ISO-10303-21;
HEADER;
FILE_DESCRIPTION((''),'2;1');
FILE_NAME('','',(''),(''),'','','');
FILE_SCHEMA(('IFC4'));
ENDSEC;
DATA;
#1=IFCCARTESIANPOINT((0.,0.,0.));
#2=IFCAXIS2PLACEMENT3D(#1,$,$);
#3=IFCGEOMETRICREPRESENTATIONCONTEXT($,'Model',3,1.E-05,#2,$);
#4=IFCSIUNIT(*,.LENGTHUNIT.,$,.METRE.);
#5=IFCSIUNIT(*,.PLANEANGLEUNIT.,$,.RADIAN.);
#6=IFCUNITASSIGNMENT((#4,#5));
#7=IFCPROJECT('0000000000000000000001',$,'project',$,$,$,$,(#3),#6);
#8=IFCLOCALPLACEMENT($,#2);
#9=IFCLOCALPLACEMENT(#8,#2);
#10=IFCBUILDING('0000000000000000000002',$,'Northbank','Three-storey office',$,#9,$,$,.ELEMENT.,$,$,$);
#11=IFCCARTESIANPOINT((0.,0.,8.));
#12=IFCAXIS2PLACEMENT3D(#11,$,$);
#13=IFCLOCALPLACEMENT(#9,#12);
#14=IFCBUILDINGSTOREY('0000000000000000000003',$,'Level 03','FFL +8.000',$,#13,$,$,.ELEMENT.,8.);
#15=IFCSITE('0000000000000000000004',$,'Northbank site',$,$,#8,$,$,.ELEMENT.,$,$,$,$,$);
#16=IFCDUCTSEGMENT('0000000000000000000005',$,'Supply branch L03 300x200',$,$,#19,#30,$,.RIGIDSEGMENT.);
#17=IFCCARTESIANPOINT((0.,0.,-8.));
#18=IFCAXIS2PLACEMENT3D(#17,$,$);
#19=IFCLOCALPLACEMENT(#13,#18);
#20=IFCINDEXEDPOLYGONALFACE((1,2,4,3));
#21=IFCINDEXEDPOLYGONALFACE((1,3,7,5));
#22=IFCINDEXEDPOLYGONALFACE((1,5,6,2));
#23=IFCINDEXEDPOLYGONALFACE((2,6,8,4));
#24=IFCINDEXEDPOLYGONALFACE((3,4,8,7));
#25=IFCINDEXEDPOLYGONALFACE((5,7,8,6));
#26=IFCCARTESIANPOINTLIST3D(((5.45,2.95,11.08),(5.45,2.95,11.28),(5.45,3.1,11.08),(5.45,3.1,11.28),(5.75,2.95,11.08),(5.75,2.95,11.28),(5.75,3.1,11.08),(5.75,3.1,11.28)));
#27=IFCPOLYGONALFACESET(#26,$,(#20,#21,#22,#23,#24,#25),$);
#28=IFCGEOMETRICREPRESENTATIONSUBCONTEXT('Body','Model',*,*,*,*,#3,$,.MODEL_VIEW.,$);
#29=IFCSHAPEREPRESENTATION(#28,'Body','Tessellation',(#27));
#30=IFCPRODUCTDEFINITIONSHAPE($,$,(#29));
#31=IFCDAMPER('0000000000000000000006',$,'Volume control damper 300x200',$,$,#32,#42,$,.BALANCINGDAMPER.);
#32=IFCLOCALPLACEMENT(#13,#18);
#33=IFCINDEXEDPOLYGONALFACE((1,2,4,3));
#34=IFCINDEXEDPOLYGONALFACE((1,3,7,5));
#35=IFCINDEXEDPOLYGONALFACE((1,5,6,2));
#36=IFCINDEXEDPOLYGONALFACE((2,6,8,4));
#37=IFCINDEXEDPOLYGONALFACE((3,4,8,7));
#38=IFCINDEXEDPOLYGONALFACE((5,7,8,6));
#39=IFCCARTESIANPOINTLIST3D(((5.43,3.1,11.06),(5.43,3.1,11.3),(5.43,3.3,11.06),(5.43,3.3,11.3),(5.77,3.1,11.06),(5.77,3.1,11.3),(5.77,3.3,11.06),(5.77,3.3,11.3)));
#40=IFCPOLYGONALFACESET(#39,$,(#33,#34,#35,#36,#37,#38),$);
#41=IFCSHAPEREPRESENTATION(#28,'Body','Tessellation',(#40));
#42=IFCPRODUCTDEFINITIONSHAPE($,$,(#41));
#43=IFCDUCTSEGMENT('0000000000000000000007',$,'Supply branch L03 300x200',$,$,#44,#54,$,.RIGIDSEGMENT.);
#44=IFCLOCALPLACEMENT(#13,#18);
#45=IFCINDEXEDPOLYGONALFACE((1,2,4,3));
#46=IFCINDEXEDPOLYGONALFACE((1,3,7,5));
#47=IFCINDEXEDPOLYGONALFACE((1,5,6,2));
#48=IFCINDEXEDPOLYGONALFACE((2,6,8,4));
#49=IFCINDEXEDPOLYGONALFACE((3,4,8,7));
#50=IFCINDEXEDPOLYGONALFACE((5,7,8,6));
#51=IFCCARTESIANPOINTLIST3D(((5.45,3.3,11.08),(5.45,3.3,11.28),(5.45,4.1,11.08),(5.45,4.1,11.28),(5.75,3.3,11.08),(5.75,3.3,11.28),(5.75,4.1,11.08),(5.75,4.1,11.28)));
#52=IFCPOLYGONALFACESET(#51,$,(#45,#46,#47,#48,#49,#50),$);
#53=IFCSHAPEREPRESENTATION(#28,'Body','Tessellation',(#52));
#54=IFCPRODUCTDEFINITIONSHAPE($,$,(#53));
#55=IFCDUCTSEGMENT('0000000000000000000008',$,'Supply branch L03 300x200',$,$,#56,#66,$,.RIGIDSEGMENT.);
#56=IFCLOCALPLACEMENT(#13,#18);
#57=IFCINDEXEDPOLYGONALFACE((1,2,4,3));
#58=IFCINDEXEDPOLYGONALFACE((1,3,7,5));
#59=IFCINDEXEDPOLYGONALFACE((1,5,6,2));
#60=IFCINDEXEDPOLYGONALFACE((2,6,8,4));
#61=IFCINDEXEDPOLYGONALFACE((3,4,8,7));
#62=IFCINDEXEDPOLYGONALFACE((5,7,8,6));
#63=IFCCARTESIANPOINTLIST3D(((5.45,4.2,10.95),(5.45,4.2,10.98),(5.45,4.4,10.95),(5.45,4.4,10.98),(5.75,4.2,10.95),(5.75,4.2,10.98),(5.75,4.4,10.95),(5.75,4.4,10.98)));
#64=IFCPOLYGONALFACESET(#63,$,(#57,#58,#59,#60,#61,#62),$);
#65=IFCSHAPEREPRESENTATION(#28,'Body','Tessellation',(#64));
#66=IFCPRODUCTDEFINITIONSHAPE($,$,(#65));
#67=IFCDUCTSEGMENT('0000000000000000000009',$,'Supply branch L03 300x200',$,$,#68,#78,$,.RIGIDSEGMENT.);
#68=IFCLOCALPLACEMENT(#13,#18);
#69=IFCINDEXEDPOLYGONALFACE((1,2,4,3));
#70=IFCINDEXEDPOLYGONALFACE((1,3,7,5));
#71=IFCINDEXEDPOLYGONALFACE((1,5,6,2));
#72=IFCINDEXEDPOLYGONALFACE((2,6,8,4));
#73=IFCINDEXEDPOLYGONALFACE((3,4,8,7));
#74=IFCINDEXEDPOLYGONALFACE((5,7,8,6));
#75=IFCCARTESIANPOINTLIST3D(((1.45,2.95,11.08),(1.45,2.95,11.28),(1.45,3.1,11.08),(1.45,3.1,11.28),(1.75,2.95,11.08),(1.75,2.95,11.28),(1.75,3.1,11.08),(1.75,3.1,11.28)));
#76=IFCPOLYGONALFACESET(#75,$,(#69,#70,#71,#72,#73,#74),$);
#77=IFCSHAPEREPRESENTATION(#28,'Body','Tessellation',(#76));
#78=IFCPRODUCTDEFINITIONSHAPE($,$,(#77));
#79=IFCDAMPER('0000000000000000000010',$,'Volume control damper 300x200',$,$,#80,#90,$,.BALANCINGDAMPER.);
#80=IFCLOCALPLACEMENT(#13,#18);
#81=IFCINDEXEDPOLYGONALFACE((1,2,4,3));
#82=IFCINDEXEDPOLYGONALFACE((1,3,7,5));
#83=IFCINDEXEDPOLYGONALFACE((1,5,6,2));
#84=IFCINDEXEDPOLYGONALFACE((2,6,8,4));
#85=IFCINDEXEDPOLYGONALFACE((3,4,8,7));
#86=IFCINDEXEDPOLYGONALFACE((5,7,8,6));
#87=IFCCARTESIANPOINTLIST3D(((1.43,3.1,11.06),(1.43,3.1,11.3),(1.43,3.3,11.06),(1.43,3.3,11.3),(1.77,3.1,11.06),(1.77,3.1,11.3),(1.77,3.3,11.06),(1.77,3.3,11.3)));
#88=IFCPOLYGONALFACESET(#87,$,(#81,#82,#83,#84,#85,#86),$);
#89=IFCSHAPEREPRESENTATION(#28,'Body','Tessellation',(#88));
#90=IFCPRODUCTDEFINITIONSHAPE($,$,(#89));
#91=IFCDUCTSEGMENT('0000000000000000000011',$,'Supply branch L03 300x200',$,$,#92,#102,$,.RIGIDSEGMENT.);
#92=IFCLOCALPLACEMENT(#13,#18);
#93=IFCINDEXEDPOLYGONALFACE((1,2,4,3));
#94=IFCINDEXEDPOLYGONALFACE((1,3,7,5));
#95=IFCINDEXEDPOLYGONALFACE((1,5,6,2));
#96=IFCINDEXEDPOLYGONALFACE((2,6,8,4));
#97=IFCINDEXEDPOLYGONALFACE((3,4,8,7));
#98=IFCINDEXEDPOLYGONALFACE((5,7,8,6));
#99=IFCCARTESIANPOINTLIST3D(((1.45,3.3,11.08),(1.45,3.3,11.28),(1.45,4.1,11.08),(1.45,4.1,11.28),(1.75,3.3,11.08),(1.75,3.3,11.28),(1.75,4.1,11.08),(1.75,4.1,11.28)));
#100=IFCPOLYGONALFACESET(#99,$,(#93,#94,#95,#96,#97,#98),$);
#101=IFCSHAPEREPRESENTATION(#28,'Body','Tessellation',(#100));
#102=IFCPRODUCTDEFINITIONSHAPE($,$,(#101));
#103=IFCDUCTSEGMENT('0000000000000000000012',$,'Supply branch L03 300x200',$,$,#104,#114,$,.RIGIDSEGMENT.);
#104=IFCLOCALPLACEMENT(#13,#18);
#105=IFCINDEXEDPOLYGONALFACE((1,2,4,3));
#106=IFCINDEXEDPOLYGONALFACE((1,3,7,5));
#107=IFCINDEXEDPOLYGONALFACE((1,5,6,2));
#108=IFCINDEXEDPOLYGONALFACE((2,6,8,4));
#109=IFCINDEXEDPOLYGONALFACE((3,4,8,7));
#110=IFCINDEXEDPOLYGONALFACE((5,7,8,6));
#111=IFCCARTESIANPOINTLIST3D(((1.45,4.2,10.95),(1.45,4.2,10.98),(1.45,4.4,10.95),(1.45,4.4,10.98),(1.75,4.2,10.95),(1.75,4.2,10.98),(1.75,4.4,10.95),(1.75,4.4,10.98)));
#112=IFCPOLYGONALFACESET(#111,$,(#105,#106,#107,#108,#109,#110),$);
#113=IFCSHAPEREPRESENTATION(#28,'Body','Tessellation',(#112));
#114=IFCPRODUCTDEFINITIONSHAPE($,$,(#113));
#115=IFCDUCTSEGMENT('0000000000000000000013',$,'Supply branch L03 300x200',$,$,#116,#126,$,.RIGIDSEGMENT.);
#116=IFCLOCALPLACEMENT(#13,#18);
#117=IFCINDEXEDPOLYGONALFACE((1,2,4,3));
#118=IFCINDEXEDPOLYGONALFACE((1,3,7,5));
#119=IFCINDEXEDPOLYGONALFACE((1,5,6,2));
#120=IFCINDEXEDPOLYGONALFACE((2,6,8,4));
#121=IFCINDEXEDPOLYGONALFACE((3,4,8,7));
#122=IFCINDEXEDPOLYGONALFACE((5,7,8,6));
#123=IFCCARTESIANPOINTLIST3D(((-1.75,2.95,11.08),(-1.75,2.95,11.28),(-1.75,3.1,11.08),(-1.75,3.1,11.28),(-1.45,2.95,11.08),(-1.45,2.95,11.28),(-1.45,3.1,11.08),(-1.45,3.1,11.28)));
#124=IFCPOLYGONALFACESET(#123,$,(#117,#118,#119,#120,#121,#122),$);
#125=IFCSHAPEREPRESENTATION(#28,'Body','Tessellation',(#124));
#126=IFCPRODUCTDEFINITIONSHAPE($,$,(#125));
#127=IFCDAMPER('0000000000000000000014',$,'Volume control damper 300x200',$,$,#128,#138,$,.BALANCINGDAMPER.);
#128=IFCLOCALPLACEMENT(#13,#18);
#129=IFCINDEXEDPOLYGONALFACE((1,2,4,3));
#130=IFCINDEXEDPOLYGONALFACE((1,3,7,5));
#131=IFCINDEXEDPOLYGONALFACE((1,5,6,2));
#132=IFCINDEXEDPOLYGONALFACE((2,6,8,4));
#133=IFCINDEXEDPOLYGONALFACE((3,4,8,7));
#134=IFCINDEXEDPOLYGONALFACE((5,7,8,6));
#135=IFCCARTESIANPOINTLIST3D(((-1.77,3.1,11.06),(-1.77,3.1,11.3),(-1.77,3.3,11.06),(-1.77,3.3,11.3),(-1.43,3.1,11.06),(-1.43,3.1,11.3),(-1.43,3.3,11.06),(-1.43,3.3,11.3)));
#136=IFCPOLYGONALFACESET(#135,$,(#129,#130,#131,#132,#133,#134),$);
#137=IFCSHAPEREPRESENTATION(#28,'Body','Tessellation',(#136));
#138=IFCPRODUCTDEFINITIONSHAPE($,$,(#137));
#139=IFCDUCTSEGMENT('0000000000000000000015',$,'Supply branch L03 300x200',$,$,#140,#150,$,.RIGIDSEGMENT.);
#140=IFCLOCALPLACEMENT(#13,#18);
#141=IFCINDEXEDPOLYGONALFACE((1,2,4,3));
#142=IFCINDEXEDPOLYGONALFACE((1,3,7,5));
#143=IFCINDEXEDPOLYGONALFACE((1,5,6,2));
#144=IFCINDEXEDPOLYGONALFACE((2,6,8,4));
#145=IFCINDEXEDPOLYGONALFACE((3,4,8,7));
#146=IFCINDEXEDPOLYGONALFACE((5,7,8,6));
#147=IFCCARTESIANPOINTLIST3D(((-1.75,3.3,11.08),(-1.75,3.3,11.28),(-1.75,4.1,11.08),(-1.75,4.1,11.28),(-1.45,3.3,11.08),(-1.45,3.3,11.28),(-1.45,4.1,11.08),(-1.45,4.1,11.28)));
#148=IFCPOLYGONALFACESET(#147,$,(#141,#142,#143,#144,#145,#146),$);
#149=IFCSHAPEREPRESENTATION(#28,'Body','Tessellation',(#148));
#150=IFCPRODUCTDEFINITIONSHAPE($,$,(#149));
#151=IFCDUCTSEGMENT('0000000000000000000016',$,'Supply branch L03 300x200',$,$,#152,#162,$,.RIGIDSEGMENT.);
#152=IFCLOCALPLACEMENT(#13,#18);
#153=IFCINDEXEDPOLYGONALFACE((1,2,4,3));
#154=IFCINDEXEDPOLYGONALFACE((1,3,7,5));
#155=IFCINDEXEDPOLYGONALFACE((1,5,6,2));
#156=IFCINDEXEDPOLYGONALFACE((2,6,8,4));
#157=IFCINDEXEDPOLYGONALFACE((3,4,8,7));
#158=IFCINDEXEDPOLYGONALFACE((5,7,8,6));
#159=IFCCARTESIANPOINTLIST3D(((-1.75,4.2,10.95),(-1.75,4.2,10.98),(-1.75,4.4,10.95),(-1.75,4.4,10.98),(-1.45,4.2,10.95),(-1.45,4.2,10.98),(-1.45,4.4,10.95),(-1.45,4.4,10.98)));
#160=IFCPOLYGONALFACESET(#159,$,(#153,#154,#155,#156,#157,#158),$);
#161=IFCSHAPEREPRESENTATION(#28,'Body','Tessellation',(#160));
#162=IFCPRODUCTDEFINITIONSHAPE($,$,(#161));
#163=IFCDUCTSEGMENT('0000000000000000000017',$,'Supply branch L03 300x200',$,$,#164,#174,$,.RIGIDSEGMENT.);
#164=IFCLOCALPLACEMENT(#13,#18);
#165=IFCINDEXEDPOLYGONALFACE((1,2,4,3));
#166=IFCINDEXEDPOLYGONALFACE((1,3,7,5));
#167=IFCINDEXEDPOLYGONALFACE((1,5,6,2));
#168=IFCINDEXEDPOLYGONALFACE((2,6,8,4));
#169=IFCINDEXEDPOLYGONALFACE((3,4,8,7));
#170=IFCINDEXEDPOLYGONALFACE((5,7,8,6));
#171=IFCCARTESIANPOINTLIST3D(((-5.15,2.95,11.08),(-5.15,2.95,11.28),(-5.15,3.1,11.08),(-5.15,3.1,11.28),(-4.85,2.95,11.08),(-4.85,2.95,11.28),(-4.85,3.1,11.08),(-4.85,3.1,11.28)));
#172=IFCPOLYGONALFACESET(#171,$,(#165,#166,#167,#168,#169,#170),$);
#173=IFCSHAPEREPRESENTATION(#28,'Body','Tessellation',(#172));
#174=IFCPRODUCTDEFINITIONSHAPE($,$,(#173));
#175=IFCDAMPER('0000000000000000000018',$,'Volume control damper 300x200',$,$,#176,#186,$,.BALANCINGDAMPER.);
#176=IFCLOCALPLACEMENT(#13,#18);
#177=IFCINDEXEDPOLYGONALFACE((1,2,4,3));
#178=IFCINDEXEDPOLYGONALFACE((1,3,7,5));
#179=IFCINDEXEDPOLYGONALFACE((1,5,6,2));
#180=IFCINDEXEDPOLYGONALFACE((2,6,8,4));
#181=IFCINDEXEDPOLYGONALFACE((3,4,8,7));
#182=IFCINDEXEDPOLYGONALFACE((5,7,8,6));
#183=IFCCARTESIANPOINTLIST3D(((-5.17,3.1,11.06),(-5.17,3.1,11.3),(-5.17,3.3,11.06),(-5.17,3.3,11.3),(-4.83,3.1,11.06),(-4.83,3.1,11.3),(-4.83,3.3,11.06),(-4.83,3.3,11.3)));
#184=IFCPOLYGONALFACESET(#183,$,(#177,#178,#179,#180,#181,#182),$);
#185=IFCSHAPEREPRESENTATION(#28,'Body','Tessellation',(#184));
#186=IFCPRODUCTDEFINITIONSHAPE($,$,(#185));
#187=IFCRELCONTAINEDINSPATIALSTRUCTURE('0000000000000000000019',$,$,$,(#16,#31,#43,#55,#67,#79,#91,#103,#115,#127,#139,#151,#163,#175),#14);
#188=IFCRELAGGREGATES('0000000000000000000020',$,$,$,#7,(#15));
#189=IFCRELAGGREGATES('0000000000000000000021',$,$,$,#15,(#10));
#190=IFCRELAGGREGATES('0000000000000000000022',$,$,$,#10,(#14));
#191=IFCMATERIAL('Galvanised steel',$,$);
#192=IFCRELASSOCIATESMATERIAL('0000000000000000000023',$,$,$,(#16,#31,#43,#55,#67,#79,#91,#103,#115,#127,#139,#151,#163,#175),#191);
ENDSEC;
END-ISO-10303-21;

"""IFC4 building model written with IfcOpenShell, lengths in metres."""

from ifc_helpers import new_model, si_unit, frame, origin, place, context, subcontext, project, spatial, rectangle, extrude, material, element, save


model = new_model("IFC4")

# Units and contexts
model_context = context("Model", 3, precision=1e-05, world=origin())
body_context = subcontext(model_context, "Body", "Model", "MODEL_VIEW")
ifc_project = project(units=[si_unit("LENGTHUNIT", "METRE"), si_unit("PLANEANGLEUNIT", "RADIAN")], contexts=[model_context])

# Site, building, storey
site_placement = place(None, origin())
site = spatial("IfcSite", under=ifc_project, at=site_placement, Name="Northbank site", CompositionType="ELEMENT")
building_placement = place(site_placement, origin())
building = spatial("IfcBuilding", under=site, at=building_placement, Name="Northbank", Description="Three-storey office", CompositionType="ELEMENT")
storey_placement = place(building_placement, frame((0.0, 0.0, 8.0)))
storey = spatial("IfcBuildingStorey", under=building, at=storey_placement, Name="Level 03", Description="FFL +8.000", CompositionType="ELEMENT", Elevation=8.0)

# Duct segment
ifc_material_1 = material(Name="Galvanised steel")
duct_segment_1_placement = place(storey_placement, frame((0.0, 0.0, -8.0)))
element("IfcDuctSegment", 1, at=duct_segment_1_placement, inside=storey, material=ifc_material_1, Name="Supply branch L03 300x200", PredefinedType="RIGIDSEGMENT", context=body_context, shape_type="SweptSolid", body=[
    extrude(rectangle(XDim=0.3, YDim=0.2), frame((5.6, 2.95, 11.18), z_axis=(0.0, 1.0, 0.0), x_axis=(-1.0, 0.0, 0.0)), (0.0, 0.0, 1.0), 0.15),
])

# Damper
damper_1_placement = place(storey_placement, frame((0.0, 0.0, -8.0)))
element("IfcDamper", 2, at=damper_1_placement, inside=storey, material=ifc_material_1, Name="Volume control damper 300x200", PredefinedType="BALANCINGDAMPER", context=body_context, shape_type="SweptSolid", body=[
    extrude(rectangle(XDim=0.34, YDim=0.24), frame((5.6, 3.1, 11.18), z_axis=(0.0, 1.0, 0.0), x_axis=(-1.0, 0.0, 0.0)), (0.0, 0.0, 1.0), 0.2),
])

# Duct segments
duct_segment_2_placement = place(storey_placement, frame((0.0, 0.0, -8.0)))
element("IfcDuctSegment", 3, at=duct_segment_2_placement, inside=storey, material=ifc_material_1, Name="Supply branch L03 300x200", PredefinedType="RIGIDSEGMENT", context=body_context, shape_type="SweptSolid", body=[
    extrude(rectangle(XDim=0.3, YDim=0.2), frame((5.6, 3.3, 11.18), z_axis=(0.0, 1.0, 0.0), x_axis=(-1.0, 0.0, 0.0)), (0.0, 0.0, 1.0), 0.8),
])
duct_segment_3_placement = place(storey_placement, frame((0.0, 0.0, -8.0)))
element("IfcDuctSegment", 4, at=duct_segment_3_placement, inside=storey, material=ifc_material_1, Name="Supply branch L03 300x200", PredefinedType="RIGIDSEGMENT", context=body_context, shape_type="SweptSolid", body=[
    extrude(rectangle(XDim=0.3, YDim=0.2), frame((5.6, 4.3, 10.98), z_axis=(0.0, 0.0, -1.0), x_axis=(-1.0, 0.0, 0.0)), (0.0, 0.0, 1.0), 0.03),
])

# Duct segment
duct_segment_4_placement = place(storey_placement, frame((0.0, 0.0, -8.0)))
element("IfcDuctSegment", 5, at=duct_segment_4_placement, inside=storey, material=ifc_material_1, Name="Supply branch L03 300x200", PredefinedType="RIGIDSEGMENT", context=body_context, shape_type="SweptSolid", body=[
    extrude(rectangle(XDim=0.3, YDim=0.2), frame((1.6, 2.95, 11.18), z_axis=(0.0, 1.0, 0.0), x_axis=(-1.0, 0.0, 0.0)), (0.0, 0.0, 1.0), 0.15),
])

# Damper
damper_2_placement = place(storey_placement, frame((0.0, 0.0, -8.0)))
element("IfcDamper", 6, at=damper_2_placement, inside=storey, material=ifc_material_1, Name="Volume control damper 300x200", PredefinedType="BALANCINGDAMPER", context=body_context, shape_type="SweptSolid", body=[
    extrude(rectangle(XDim=0.34, YDim=0.24), frame((1.6, 3.1, 11.18), z_axis=(0.0, 1.0, 0.0), x_axis=(-1.0, 0.0, 0.0)), (0.0, 0.0, 1.0), 0.2),
])

# Duct segments
duct_segment_5_placement = place(storey_placement, frame((0.0, 0.0, -8.0)))
element("IfcDuctSegment", 7, at=duct_segment_5_placement, inside=storey, material=ifc_material_1, Name="Supply branch L03 300x200", PredefinedType="RIGIDSEGMENT", context=body_context, shape_type="SweptSolid", body=[
    extrude(rectangle(XDim=0.3, YDim=0.2), frame((1.6, 3.3, 11.18), z_axis=(0.0, 1.0, 0.0), x_axis=(-1.0, 0.0, 0.0)), (0.0, 0.0, 1.0), 0.8),
])
duct_segment_6_placement = place(storey_placement, frame((0.0, 0.0, -8.0)))
element("IfcDuctSegment", 8, at=duct_segment_6_placement, inside=storey, material=ifc_material_1, Name="Supply branch L03 300x200", PredefinedType="RIGIDSEGMENT", context=body_context, shape_type="SweptSolid", body=[
    extrude(rectangle(XDim=0.3, YDim=0.2), frame((1.6, 4.3, 10.98), z_axis=(0.0, 0.0, -1.0), x_axis=(-1.0, 0.0, 0.0)), (0.0, 0.0, 1.0), 0.03),
])

# Duct segment
duct_segment_7_placement = place(storey_placement, frame((0.0, 0.0, -8.0)))
element("IfcDuctSegment", 9, at=duct_segment_7_placement, inside=storey, material=ifc_material_1, Name="Supply branch L03 300x200", PredefinedType="RIGIDSEGMENT", context=body_context, shape_type="SweptSolid", body=[
    extrude(rectangle(XDim=0.3, YDim=0.2), frame((-1.6, 2.95, 11.18), z_axis=(0.0, 1.0, 0.0), x_axis=(-1.0, 0.0, 0.0)), (0.0, 0.0, 1.0), 0.15),
])

# Damper
damper_3_placement = place(storey_placement, frame((0.0, 0.0, -8.0)))
element("IfcDamper", 10, at=damper_3_placement, inside=storey, material=ifc_material_1, Name="Volume control damper 300x200", PredefinedType="BALANCINGDAMPER", context=body_context, shape_type="SweptSolid", body=[
    extrude(rectangle(XDim=0.34, YDim=0.24), frame((-1.6, 3.1, 11.18), z_axis=(0.0, 1.0, 0.0), x_axis=(-1.0, 0.0, 0.0)), (0.0, 0.0, 1.0), 0.2),
])

# Duct segments
duct_segment_8_placement = place(storey_placement, frame((0.0, 0.0, -8.0)))
element("IfcDuctSegment", 11, at=duct_segment_8_placement, inside=storey, material=ifc_material_1, Name="Supply branch L03 300x200", PredefinedType="RIGIDSEGMENT", context=body_context, shape_type="SweptSolid", body=[
    extrude(rectangle(XDim=0.3, YDim=0.2), frame((-1.6, 3.3, 11.18), z_axis=(0.0, 1.0, 0.0), x_axis=(-1.0, 0.0, 0.0)), (0.0, 0.0, 1.0), 0.8),
])
duct_segment_9_placement = place(storey_placement, frame((0.0, 0.0, -8.0)))
element("IfcDuctSegment", 12, at=duct_segment_9_placement, inside=storey, material=ifc_material_1, Name="Supply branch L03 300x200", PredefinedType="RIGIDSEGMENT", context=body_context, shape_type="SweptSolid", body=[
    extrude(rectangle(XDim=0.3, YDim=0.2), frame((-1.6, 4.3, 10.98), z_axis=(0.0, 0.0, -1.0), x_axis=(-1.0, 0.0, 0.0)), (0.0, 0.0, 1.0), 0.03),
])

# Duct segment
duct_segment_10_placement = place(storey_placement, frame((0.0, 0.0, -8.0)))
element("IfcDuctSegment", 13, at=duct_segment_10_placement, inside=storey, material=ifc_material_1, Name="Supply branch L03 300x200", PredefinedType="RIGIDSEGMENT", context=body_context, shape_type="SweptSolid", body=[
    extrude(rectangle(XDim=0.3, YDim=0.2), frame((-5.0, 2.95, 11.18), z_axis=(0.0, 1.0, 0.0), x_axis=(-1.0, 0.0, 0.0)), (0.0, 0.0, 1.0), 0.15),
])

# Damper
damper_4_placement = place(storey_placement, frame((0.0, 0.0, -8.0)))
element("IfcDamper", 14, at=damper_4_placement, inside=storey, material=ifc_material_1, Name="Volume control damper 300x200", PredefinedType="BALANCINGDAMPER", context=body_context, shape_type="SweptSolid", body=[
    extrude(rectangle(XDim=0.34, YDim=0.24), frame((-5.0, 3.1, 11.18), z_axis=(0.0, 1.0, 0.0), x_axis=(-1.0, 0.0, 0.0)), (0.0, 0.0, 1.0), 0.2),
])

save(model, "model.ifc")
